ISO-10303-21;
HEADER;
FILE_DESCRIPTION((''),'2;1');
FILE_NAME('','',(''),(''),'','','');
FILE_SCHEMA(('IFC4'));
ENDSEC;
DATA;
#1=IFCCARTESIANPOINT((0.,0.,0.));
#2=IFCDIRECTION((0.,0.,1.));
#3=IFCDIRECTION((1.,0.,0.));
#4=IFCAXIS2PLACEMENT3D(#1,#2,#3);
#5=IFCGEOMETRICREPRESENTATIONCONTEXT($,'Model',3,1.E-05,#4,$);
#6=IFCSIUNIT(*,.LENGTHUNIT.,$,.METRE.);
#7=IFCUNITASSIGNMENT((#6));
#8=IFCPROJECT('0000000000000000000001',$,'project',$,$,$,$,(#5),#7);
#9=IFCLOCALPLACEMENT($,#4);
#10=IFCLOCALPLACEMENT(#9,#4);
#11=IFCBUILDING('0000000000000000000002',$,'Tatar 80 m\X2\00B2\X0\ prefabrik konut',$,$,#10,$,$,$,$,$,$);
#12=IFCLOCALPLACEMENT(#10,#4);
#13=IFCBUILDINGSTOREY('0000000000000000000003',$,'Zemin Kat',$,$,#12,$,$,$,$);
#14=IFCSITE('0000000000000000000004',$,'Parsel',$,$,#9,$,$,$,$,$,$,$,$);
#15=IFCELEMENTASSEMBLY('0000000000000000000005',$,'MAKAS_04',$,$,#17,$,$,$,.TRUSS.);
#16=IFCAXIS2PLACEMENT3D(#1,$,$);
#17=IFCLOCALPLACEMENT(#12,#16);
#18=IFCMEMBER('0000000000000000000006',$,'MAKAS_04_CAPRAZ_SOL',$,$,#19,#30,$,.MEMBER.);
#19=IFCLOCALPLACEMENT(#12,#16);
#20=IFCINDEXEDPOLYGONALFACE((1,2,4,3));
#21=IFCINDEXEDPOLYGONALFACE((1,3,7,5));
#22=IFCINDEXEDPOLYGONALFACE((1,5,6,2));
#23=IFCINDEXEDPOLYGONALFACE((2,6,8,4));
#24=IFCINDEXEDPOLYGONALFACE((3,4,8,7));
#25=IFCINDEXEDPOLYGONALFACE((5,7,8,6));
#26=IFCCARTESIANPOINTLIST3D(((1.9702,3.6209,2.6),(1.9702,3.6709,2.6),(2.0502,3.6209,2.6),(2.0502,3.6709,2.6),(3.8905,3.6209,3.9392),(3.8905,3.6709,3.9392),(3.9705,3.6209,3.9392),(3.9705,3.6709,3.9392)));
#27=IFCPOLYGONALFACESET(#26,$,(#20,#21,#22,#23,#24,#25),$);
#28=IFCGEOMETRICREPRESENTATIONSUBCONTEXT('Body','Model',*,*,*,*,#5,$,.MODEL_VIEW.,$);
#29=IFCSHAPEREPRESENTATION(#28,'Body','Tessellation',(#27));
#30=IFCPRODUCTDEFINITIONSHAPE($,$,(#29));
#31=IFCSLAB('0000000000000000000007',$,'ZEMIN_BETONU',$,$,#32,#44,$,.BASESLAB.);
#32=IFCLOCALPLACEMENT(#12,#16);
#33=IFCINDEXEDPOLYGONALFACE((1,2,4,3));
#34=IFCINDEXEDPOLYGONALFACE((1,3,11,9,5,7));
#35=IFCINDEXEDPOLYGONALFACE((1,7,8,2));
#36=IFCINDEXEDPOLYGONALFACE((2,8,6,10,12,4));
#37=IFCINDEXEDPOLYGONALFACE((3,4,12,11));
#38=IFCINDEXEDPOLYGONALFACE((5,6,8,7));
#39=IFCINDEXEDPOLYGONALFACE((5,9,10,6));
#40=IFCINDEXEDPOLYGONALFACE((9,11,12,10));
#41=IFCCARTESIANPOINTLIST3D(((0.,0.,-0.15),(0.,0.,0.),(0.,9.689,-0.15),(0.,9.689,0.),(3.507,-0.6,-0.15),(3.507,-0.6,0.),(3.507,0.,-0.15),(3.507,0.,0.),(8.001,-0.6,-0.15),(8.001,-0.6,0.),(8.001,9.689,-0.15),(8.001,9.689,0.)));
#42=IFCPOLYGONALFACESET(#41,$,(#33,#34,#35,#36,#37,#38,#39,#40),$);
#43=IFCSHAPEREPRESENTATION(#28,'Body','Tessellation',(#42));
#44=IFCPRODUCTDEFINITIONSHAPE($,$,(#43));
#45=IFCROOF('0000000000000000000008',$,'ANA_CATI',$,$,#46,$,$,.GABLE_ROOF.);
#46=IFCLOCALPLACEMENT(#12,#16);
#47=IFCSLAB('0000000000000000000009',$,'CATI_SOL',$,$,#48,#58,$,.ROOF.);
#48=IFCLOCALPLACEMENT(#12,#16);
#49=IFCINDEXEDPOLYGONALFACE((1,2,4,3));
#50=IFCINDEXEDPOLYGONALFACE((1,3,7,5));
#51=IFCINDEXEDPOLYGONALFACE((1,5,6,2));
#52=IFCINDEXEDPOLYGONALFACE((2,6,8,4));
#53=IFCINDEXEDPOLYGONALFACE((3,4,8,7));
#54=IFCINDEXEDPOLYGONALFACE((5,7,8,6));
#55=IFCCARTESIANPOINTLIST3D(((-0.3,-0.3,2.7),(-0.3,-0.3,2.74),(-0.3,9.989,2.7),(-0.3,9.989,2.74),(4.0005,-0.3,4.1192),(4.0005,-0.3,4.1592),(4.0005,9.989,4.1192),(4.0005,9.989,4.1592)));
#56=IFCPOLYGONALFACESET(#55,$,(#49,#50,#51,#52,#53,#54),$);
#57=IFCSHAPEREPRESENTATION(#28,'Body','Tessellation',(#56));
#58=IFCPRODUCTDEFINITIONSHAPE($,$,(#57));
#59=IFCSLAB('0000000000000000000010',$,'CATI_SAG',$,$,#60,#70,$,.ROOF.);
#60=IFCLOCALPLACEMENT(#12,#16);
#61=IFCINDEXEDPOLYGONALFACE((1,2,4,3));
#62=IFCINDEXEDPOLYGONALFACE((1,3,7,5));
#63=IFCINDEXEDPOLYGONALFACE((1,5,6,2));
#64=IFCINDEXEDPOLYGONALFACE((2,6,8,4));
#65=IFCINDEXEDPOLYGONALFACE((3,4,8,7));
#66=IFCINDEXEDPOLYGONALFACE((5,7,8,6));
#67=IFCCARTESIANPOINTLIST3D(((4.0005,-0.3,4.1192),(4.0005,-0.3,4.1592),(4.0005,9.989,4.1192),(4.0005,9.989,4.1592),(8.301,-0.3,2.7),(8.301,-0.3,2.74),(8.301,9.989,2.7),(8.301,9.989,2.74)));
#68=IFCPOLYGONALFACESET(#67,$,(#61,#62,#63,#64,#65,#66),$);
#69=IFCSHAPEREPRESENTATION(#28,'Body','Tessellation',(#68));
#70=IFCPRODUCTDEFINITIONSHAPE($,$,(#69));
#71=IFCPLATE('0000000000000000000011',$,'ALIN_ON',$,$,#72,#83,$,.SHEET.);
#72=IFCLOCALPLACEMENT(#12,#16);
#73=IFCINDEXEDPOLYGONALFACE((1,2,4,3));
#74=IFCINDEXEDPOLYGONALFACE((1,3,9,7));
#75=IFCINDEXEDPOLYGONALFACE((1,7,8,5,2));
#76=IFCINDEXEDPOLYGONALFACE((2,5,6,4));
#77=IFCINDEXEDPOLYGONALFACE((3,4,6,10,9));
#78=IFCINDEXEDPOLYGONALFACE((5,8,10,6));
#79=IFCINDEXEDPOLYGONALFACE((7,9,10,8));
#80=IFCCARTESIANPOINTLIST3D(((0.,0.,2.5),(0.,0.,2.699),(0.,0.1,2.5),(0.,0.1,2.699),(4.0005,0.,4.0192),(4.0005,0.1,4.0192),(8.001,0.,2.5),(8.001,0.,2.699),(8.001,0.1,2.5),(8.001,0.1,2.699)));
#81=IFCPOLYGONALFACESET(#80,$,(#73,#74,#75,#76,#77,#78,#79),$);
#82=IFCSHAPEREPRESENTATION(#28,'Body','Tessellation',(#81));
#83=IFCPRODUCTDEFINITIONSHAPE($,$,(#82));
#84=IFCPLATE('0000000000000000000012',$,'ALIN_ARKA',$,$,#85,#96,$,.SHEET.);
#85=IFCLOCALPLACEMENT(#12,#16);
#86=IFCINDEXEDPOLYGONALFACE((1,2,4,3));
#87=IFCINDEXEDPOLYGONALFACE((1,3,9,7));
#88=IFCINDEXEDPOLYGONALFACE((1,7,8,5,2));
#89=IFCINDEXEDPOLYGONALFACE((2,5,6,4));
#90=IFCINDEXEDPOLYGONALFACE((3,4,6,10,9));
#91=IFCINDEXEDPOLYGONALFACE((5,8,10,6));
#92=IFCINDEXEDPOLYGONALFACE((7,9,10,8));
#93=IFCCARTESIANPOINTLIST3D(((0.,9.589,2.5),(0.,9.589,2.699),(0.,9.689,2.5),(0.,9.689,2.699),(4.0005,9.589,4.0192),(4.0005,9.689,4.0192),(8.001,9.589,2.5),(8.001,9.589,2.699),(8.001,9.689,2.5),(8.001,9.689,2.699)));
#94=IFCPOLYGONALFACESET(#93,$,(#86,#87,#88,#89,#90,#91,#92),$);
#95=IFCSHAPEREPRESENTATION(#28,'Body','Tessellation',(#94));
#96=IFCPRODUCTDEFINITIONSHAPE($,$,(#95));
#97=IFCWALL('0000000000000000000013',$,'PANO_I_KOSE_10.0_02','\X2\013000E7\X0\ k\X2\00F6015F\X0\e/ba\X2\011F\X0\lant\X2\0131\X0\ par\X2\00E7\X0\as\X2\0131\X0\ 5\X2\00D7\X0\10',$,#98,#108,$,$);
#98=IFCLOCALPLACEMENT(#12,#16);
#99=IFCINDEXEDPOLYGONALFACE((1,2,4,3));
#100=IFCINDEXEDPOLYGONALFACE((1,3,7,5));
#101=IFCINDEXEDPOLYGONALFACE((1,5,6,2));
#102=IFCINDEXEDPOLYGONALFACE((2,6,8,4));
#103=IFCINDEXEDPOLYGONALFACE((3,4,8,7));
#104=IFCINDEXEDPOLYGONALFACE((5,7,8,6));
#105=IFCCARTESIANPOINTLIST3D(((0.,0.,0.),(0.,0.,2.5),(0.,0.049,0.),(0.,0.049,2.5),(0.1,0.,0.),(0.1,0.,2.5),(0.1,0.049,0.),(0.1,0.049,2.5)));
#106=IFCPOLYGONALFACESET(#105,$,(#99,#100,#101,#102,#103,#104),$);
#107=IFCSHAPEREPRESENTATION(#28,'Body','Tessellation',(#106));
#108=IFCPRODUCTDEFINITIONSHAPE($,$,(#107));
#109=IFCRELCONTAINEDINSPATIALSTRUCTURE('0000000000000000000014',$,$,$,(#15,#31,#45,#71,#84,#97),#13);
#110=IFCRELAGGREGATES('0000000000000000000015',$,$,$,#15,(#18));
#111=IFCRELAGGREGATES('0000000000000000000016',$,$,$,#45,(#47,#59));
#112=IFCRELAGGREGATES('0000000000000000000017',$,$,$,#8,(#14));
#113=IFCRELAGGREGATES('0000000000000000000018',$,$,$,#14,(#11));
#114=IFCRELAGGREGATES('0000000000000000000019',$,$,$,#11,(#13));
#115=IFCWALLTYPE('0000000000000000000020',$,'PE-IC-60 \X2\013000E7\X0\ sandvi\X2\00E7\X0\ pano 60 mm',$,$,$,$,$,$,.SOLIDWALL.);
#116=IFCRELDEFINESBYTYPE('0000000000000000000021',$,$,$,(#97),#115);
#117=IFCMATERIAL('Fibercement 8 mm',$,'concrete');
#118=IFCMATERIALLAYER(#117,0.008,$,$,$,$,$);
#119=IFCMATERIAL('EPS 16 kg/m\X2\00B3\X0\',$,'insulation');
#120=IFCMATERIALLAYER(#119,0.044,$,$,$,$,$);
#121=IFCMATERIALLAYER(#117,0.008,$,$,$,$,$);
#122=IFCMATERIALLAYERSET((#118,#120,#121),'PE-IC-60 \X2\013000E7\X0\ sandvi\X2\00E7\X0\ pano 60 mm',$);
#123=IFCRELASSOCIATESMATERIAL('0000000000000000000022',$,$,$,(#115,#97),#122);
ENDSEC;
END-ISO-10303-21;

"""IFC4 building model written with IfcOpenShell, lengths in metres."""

from ifc_helpers import new_model, si_unit, frame, origin_with_axes, place, context, subcontext, project, spatial, line, indexed_curve, outline, extrude, material, layer, layer_set, layer_usage, type_object, element, aggregate, save


model = new_model("IFC4")

# Units and contexts
model_context = context("Model", 3, precision=1e-05, world=origin_with_axes())
body_context = subcontext(model_context, "Body", "Model", "MODEL_VIEW")
ifc_project = project(units=[si_unit("LENGTHUNIT", "METRE")], contexts=[model_context])

# Site, building, storey
site_placement = place(None, origin_with_axes())
site = spatial("IfcSite", under=ifc_project, at=site_placement, Name="Parsel")
building_placement = place(site_placement, origin_with_axes())
building = spatial("IfcBuilding", under=site, at=building_placement, Name="Tatar 80 m² prefabrik konut")
storey_placement = place(building_placement, origin_with_axes())
storey = spatial("IfcBuildingStorey", under=building, at=storey_placement, Name="Zemin Kat")

# Element assembly, member
assembly_1_placement = place(storey_placement, origin_with_axes())
assembly_1 = element("IfcElementAssembly", 1, at=assembly_1_placement, inside=storey, Name="MAKAS_04", PredefinedType="TRUSS")
member_1_placement = place(assembly_1_placement, origin_with_axes())
member_1 = element("IfcMember", 2, at=member_1_placement, Name="MAKAS_04_CAPRAZ_SOL", PredefinedType="MEMBER", context=body_context, shape_type="SweptSolid", body=[
    extrude(outline(indexed_curve([(1.9703, 2.6), (2.0503, 2.6), (3.9705, 3.9392), (3.8905, 3.9392)], segments=[line(1, 2, 3, 4, 1)])), frame((0.0, 3.6709, 0.0), z_axis=(0.0, -1.0, 0.0), x_axis=(1.0, 0.0, 0.0)), (0.0, 0.0, 1.0), 0.05),
])
aggregate(assembly_1, [member_1])

# Slab
slab_1_placement = place(storey_placement, origin_with_axes())
element("IfcSlab", 3, at=slab_1_placement, inside=storey, Name="ZEMIN_BETONU", PredefinedType="BASESLAB", context=body_context, shape_type="SweptSolid", body=[
    extrude(outline(indexed_curve([(0.0, 0.0), (3.507, 0.0), (3.507, -0.6), (8.001, -0.6), (8.001, 9.689), (0.0, 9.689)], segments=[line(1, 2, 3, 4, 5, 6, 1)])), frame((0.0, 0.0, -0.15), z_axis=(0.0, 0.0, 1.0), x_axis=(1.0, 0.0, 0.0)), (0.0, 0.0, 1.0), 0.15),
])

# Roof, slabs
roof_placement = place(storey_placement, origin_with_axes())
roof = element("IfcRoof", 4, at=roof_placement, inside=storey, Name="ANA_CATI", PredefinedType="GABLE_ROOF")
slab_2_placement = place(roof_placement, origin_with_axes())
slab_2 = element("IfcSlab", 5, at=slab_2_placement, Name="CATI_SOL", PredefinedType="ROOF", context=body_context, shape_type="SweptSolid", body=[
    extrude(outline(indexed_curve([(-0.3, 2.7), (4.0005, 4.1192), (4.0005, 4.1592), (-0.3, 2.74)], segments=[line(1, 2, 3, 4, 1)])), frame((0.0, 9.989, 0.0), z_axis=(0.0, -1.0, 0.0), x_axis=(1.0, 0.0, 0.0)), (0.0, 0.0, 1.0), 10.289),
])
slab_3_placement = place(roof_placement, origin_with_axes())
slab_3 = element("IfcSlab", 6, at=slab_3_placement, Name="CATI_SAG", PredefinedType="ROOF", context=body_context, shape_type="SweptSolid", body=[
    extrude(outline(indexed_curve([(4.0005, 4.1192), (8.301, 2.7), (8.301, 2.74), (4.0005, 4.1592)], segments=[line(1, 2, 3, 4, 1)])), frame((0.0, 9.989, 0.0), z_axis=(0.0, -1.0, 0.0), x_axis=(1.0, 0.0, 0.0)), (0.0, 0.0, 1.0), 10.289),
])
aggregate(roof, [slab_2, slab_3])

# Plates
plate_1_placement = place(storey_placement, origin_with_axes())
element("IfcPlate", 7, at=plate_1_placement, inside=storey, Name="ALIN_ON", PredefinedType="SHEET", context=body_context, shape_type="SweptSolid", body=[
    extrude(outline(indexed_curve([(0.0, 2.5), (8.001, 2.5), (8.001, 2.699), (4.0005, 4.0192), (0.0, 2.699)], segments=[line(1, 2, 3, 4, 5, 1)])), frame((0.0, 0.1, 0.0), z_axis=(0.0, -1.0, 0.0), x_axis=(1.0, 0.0, 0.0)), (0.0, 0.0, 1.0), 0.1),
])
plate_2_placement = place(storey_placement, origin_with_axes())
element("IfcPlate", 8, at=plate_2_placement, inside=storey, Name="ALIN_ARKA", PredefinedType="SHEET", context=body_context, shape_type="SweptSolid", body=[
    extrude(outline(indexed_curve([(0.0, 2.5), (8.001, 2.5), (8.001, 2.699), (4.0005, 4.0192), (0.0, 2.699)], segments=[line(1, 2, 3, 4, 5, 1)])), frame((0.0, 9.689, 0.0), z_axis=(0.0, -1.0, 0.0), x_axis=(1.0, 0.0, 0.0)), (0.0, 0.0, 1.0), 0.1),
])

# Wall
ifc_material_1 = material(Name="Fibercement 8 mm", Category="concrete")
ifc_layer_1 = layer(ifc_material_1, 0.008)
ifc_material_2 = material(Name="EPS 16 kg/m³", Category="insulation")
ifc_layer_2 = layer(ifc_material_2, 0.044)
ifc_layer_3 = layer(ifc_material_1, 0.008)
ifc_layer_set = layer_set([ifc_layer_1, ifc_layer_2, ifc_layer_3], Name="PE-IC-60 İç sandviç pano 60 mm")
ifc_layer_usage = layer_usage(ifc_layer_set, "AXIS2", "POSITIVE", 0.0)
wall_type = type_object("IfcWallType", Name="PE-IC-60 İç sandviç pano 60 mm", PredefinedType="SOLIDWALL", material=ifc_layer_set)
wall_placement = place(storey_placement, origin_with_axes())
element("IfcWall", 9, at=wall_placement, inside=storey, type_object=wall_type, material=ifc_layer_usage, Name="PANO_I_KOSE_10.0_02", Description="İç köşe/bağlantı parçası 5×10", context=body_context, shape_type="SweptSolid", body=[
    extrude(outline(indexed_curve([(0.0, 0.0), (0.1, 0.0), (0.1, 0.049), (0.0, 0.049)], segments=[line(1, 2, 3, 4, 1)])), origin_with_axes(), (0.0, 0.0, 1.0), 2.5),
])

save(model, "model.ifc")
